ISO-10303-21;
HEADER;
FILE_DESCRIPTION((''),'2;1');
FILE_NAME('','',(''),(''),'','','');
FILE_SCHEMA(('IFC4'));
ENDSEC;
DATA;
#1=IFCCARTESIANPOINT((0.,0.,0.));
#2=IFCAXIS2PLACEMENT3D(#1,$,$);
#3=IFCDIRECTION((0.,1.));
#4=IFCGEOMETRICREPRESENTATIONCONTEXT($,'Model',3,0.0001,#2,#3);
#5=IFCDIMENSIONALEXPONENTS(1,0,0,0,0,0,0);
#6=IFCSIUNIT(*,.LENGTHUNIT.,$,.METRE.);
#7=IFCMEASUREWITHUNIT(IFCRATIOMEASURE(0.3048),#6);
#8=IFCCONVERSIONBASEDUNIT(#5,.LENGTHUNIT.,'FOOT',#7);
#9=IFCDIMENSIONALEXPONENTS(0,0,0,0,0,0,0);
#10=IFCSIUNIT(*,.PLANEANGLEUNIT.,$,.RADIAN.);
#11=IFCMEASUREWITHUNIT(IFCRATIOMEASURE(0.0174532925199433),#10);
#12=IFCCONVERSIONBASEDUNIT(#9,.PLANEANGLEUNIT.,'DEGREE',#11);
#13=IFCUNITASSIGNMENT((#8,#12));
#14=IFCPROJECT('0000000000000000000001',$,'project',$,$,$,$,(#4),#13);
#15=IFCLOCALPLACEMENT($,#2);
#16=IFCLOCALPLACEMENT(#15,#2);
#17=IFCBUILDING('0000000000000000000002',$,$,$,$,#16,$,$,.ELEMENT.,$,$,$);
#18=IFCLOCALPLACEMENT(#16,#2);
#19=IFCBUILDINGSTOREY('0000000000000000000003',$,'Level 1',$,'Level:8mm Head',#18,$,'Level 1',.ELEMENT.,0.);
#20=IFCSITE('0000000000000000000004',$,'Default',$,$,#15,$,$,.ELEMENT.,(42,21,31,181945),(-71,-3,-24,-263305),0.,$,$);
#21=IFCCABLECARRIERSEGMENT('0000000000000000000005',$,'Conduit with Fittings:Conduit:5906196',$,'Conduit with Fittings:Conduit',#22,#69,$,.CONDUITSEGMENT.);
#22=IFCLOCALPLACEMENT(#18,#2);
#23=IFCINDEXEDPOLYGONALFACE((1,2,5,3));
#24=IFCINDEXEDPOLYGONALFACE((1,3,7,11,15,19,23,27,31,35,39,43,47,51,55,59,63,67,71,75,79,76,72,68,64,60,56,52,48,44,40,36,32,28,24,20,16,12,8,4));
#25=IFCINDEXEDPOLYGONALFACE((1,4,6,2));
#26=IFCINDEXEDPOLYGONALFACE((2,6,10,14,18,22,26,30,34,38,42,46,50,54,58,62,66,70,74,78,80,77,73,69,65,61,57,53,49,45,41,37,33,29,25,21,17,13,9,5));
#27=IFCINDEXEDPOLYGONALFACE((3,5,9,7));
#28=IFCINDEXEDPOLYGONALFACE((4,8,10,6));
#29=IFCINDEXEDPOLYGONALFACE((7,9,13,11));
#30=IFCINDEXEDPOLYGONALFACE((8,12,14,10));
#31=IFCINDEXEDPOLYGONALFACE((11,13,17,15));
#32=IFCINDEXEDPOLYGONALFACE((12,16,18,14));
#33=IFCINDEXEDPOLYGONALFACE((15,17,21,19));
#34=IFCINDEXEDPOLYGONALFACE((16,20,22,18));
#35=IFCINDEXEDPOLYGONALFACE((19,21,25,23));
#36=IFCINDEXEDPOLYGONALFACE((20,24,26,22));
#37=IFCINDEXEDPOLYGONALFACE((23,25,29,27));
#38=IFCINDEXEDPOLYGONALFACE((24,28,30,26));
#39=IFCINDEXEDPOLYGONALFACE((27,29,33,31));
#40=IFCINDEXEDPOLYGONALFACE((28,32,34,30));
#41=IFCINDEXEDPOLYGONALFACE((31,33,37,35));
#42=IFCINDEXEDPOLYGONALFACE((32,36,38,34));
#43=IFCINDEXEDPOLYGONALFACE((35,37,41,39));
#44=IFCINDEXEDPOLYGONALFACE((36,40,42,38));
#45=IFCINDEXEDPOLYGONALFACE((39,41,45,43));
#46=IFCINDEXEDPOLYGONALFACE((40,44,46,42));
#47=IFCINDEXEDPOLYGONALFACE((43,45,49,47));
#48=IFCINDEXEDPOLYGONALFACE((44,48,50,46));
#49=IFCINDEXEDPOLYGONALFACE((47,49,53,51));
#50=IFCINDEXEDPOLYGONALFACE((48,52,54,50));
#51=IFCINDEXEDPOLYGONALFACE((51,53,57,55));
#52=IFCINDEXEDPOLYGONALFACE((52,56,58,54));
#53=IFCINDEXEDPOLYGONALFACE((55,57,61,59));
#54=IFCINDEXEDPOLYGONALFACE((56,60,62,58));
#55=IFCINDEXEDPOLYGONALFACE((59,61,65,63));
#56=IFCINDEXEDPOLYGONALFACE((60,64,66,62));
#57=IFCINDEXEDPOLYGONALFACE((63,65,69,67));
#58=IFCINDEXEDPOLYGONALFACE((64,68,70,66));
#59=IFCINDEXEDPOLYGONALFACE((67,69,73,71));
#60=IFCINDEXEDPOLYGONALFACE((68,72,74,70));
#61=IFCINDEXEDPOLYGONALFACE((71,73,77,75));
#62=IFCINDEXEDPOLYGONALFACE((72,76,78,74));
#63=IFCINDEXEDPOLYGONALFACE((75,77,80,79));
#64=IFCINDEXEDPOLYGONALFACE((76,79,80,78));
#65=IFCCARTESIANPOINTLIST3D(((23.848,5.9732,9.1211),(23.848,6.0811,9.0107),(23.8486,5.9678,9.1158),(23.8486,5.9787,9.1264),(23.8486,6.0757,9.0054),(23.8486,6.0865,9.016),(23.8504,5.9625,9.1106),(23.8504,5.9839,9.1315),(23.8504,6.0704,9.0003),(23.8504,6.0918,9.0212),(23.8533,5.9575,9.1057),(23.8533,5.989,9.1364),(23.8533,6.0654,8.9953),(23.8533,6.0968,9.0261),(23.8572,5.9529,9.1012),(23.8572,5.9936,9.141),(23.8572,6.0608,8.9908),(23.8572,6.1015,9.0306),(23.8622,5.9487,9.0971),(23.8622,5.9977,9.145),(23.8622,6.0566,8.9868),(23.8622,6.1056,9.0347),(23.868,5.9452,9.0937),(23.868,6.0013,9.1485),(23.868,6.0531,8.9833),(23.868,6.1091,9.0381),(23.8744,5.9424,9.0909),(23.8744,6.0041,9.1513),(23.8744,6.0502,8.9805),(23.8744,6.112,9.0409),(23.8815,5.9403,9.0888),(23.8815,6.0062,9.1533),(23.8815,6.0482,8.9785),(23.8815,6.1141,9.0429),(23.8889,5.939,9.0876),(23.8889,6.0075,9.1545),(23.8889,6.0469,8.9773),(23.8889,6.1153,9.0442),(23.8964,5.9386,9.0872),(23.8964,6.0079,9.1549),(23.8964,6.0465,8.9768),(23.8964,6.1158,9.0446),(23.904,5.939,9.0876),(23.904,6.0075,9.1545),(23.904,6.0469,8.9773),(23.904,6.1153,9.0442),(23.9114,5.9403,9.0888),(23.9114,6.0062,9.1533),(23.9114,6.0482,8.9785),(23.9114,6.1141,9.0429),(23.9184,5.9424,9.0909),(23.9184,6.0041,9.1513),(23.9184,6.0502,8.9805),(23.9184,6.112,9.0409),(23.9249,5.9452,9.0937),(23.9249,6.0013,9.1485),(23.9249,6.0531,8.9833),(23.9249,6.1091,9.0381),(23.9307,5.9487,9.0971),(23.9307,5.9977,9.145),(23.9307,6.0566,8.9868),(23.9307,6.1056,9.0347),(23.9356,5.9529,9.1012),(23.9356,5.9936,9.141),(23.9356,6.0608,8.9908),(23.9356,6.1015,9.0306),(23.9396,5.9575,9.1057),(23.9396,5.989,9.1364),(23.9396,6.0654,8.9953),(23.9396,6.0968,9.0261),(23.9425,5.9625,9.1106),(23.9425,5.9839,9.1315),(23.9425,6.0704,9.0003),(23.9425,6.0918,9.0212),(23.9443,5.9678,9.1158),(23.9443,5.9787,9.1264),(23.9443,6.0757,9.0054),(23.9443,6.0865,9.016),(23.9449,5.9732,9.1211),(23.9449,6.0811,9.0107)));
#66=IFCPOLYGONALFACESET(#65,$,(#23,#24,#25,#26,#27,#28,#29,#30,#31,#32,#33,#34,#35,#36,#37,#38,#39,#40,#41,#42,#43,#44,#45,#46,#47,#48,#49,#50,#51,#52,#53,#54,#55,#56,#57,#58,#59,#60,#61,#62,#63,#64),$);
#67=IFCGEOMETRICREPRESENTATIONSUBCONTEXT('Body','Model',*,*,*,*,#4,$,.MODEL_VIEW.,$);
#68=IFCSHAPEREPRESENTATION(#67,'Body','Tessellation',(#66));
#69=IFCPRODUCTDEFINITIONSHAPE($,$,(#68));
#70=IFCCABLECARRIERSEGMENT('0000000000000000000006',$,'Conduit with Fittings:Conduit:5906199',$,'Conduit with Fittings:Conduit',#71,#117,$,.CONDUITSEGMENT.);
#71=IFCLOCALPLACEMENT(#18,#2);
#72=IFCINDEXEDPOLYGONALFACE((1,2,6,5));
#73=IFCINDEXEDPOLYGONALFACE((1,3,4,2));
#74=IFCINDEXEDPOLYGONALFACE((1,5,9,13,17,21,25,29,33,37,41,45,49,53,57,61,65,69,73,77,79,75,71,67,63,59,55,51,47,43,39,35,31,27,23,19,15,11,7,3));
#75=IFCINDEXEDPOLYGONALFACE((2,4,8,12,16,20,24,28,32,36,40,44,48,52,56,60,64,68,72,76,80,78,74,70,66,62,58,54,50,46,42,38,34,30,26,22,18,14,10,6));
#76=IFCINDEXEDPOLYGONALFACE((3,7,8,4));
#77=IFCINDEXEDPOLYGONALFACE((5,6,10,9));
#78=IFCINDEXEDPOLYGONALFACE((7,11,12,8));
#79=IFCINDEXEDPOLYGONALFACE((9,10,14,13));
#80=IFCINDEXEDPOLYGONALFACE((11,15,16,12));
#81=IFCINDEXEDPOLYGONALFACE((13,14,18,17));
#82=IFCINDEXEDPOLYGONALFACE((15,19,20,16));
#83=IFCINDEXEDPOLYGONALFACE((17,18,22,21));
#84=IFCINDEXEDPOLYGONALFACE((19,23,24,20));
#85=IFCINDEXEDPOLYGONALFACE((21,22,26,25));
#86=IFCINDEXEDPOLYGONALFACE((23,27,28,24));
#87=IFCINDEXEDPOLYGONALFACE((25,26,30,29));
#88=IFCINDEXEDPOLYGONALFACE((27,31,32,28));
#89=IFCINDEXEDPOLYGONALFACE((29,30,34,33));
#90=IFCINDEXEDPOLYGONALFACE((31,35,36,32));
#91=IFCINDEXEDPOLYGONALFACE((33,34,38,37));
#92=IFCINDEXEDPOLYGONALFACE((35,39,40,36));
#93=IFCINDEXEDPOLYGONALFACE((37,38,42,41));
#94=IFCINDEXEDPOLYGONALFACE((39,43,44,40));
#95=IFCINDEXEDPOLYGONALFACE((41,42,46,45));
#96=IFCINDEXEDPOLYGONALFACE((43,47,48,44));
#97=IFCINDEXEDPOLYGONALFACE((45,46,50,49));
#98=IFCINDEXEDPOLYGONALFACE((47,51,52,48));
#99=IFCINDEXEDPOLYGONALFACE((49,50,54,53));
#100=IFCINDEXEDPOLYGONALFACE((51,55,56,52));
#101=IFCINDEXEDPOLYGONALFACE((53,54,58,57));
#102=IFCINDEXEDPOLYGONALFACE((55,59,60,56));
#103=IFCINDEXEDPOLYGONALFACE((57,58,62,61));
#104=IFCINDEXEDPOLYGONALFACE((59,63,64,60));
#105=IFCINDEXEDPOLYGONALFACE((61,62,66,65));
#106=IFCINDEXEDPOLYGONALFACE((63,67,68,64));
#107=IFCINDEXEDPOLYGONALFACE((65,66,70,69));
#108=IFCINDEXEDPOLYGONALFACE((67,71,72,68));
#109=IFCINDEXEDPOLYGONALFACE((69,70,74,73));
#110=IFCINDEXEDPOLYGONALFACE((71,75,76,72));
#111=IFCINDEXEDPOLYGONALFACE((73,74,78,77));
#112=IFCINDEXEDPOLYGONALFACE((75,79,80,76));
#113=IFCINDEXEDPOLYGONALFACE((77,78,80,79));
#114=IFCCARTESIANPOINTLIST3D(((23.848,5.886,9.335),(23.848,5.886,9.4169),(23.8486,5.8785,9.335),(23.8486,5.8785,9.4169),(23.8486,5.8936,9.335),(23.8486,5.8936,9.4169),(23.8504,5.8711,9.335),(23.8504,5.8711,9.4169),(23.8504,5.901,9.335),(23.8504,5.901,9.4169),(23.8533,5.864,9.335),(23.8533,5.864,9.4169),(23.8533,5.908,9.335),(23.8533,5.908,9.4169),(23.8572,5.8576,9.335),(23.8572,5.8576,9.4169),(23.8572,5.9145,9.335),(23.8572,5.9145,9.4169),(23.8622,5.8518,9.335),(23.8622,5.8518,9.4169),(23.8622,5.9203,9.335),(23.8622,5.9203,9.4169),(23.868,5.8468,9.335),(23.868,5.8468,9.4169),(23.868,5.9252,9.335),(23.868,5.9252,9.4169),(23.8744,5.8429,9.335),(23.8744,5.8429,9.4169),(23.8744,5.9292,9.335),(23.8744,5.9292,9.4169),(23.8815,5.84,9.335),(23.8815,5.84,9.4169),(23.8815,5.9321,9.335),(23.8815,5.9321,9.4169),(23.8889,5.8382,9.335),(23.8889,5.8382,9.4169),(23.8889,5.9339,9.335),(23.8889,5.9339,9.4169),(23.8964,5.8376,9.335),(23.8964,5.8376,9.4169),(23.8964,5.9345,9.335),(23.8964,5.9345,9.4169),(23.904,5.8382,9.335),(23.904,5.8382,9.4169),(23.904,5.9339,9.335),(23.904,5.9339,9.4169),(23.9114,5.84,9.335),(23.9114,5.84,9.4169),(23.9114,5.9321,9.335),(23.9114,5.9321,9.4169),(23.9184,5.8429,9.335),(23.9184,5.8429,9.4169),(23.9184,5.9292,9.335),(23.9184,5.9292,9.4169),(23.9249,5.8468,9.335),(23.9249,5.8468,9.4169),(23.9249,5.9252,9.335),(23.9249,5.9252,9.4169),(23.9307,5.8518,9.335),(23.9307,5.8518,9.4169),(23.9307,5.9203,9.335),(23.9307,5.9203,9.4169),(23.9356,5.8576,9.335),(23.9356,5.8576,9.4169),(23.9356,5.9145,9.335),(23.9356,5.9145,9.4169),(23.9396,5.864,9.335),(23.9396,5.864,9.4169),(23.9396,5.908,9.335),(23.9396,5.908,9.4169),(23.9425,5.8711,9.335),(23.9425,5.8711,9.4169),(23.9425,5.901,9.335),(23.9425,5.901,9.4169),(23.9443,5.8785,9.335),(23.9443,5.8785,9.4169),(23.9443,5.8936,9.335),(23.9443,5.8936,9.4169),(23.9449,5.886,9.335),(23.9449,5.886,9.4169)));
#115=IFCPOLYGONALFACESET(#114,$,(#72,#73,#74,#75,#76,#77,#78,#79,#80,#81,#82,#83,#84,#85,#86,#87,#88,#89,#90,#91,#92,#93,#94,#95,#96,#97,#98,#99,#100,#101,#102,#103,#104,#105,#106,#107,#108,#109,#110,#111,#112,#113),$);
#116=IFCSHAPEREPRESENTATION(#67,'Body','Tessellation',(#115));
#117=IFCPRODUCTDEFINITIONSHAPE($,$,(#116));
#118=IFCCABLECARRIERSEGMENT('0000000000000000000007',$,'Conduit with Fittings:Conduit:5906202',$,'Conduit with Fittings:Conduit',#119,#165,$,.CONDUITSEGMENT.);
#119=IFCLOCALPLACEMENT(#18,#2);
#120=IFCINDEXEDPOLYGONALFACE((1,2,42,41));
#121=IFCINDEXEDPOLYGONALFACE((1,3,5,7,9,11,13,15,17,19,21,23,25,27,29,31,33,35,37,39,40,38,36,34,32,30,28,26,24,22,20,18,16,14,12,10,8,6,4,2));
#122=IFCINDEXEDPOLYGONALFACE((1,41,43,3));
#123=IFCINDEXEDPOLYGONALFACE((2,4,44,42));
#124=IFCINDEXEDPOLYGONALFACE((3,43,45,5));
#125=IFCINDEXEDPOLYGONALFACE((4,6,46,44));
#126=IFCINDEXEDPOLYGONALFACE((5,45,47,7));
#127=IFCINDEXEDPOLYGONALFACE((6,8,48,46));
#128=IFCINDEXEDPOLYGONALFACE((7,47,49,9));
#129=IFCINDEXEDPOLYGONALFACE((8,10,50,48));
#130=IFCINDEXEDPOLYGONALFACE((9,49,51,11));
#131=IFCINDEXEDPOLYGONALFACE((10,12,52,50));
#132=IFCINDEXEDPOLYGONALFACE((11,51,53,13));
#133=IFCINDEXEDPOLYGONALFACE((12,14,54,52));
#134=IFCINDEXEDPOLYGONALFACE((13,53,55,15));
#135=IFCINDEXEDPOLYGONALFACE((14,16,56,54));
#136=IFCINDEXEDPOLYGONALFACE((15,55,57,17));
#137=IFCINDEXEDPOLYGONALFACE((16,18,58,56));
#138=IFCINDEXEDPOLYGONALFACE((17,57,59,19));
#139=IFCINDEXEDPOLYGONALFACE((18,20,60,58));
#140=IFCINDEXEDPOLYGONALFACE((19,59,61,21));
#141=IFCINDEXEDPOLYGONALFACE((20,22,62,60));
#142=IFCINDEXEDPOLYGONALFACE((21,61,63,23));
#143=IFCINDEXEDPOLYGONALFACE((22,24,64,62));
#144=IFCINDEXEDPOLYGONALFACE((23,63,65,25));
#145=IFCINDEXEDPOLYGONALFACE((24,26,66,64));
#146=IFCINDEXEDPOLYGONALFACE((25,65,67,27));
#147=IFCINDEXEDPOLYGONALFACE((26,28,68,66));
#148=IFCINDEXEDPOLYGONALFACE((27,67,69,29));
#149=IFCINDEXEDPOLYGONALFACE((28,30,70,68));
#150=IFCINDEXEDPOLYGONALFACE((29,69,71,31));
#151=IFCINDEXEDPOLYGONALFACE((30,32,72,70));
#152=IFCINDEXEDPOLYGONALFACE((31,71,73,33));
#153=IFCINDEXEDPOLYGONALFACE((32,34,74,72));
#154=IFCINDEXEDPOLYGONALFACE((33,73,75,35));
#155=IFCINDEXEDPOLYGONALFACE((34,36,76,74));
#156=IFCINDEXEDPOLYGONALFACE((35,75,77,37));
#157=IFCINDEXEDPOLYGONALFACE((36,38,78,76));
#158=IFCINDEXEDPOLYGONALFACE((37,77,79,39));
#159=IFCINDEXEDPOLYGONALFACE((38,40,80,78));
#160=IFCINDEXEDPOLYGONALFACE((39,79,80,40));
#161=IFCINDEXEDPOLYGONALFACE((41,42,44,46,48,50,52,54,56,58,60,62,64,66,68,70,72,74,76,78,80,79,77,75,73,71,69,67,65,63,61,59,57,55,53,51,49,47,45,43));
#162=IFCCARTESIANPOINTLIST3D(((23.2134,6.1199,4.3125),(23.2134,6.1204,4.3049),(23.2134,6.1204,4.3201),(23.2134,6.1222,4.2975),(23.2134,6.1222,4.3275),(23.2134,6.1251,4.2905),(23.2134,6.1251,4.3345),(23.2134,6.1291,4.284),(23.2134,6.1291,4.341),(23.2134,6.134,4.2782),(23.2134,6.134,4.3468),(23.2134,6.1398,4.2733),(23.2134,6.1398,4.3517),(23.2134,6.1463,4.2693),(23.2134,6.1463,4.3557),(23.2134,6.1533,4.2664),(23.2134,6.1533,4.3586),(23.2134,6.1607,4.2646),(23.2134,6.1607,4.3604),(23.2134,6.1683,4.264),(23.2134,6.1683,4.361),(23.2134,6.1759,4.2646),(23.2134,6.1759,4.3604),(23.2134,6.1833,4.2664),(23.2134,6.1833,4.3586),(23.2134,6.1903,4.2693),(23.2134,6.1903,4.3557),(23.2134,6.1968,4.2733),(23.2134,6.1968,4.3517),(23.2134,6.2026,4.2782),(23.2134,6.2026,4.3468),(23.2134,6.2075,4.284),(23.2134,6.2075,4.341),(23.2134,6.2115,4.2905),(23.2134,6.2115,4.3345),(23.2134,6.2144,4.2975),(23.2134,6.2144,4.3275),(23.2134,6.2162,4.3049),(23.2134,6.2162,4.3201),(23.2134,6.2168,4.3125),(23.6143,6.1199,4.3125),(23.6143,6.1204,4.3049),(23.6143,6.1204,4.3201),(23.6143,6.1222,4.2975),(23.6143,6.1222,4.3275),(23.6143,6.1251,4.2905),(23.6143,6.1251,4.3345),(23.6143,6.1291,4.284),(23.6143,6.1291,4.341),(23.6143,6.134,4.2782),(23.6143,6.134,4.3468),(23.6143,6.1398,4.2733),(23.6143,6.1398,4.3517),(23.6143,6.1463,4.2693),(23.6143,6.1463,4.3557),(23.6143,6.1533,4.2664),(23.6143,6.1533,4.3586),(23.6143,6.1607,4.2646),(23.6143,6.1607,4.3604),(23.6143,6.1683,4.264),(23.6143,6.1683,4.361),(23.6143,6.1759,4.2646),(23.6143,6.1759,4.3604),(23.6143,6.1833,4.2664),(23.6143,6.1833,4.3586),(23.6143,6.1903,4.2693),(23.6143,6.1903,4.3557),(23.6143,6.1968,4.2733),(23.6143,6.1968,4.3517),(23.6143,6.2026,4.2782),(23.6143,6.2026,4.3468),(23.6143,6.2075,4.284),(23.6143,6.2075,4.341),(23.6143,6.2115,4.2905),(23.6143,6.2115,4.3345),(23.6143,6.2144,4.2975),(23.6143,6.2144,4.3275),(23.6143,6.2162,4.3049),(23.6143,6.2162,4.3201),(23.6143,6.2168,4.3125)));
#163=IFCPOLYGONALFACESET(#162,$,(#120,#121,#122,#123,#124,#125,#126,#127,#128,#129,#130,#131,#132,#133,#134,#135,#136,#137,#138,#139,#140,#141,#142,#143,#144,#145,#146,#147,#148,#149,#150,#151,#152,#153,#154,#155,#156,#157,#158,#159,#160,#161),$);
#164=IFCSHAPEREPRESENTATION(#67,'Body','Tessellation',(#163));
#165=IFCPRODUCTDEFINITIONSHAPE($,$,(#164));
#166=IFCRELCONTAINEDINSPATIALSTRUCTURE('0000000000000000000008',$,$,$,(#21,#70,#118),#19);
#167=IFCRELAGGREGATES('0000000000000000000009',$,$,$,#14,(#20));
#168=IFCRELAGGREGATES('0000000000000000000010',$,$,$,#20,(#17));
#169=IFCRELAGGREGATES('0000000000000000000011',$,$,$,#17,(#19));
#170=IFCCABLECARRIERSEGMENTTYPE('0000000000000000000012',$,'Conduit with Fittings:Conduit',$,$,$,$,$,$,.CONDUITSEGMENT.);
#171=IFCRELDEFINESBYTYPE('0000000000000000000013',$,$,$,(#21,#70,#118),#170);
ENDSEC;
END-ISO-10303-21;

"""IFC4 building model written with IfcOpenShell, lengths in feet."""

from ifc_helpers import new_model, entity, si_unit, converted_unit, direction, frame, origin, place, context, subcontext, project, spatial, indexed_curve, outline, extrude, type_object, element, save


model = new_model("IFC4")

# Units and contexts
model_context = context("Model", 3, precision=0.0001, world=origin(), true_north=direction((0.0, 1.0)))
body_context = subcontext(model_context, "Body", "Model", "MODEL_VIEW")
ifc_project = project(units=[converted_unit("LENGTHUNIT", "FOOT", entity("IfcRatioMeasure", 0.3048), si_unit("LENGTHUNIT", "METRE"), dimensions=[1, 0, 0, 0, 0, 0, 0]), converted_unit("PLANEANGLEUNIT", "DEGREE", entity("IfcRatioMeasure", 0.0174532925199433), si_unit("PLANEANGLEUNIT", "RADIAN"), dimensions=[0, 0, 0, 0, 0, 0, 0])], contexts=[model_context])

# Site, building, storey
site_placement = place(None, origin())
site = spatial("IfcSite", under=ifc_project, at=site_placement, Name="Default", CompositionType="ELEMENT", RefLatitude=(42, 21, 31, 181945), RefLongitude=(-71, -3, -24, -263305), RefElevation=0.0)
building_placement = place(site_placement, origin())
building = spatial("IfcBuilding", under=site, at=building_placement, CompositionType="ELEMENT")
storey_placement = place(building_placement, origin())
storey = spatial("IfcBuildingStorey", under=building, at=storey_placement, Name="Level 1", ObjectType="Level:8mm Head", LongName="Level 1", CompositionType="ELEMENT", Elevation=0.0)

# Cable carrier segments
cable_carrier_segment_type_1 = type_object("IfcCableCarrierSegmentType", Name="Conduit with Fittings:Conduit", PredefinedType="CONDUITSEGMENT")
cable_carrier_segment_1_placement = place(storey_placement, origin())
element("IfcCableCarrierSegment", 1, at=cable_carrier_segment_1_placement, inside=storey, type_object=cable_carrier_segment_type_1, Name="Conduit with Fittings:Conduit:5906196", ObjectType="Conduit with Fittings:Conduit", PredefinedType="CONDUITSEGMENT", context=body_context, shape_type="SweptSolid", body=[
    extrude(outline(indexed_curve([(0.0485, 0.0), (0.0479, 0.0076), (0.0461, 0.015), (0.0432, 0.022), (0.0392, 0.0285), (0.0343, 0.0343), (0.0285, 0.0392), (0.022, 0.0432), (0.015, 0.0461), (0.0076, 0.0479), (0.0, 0.0485), (-0.0076, 0.0479), (-0.015, 0.0461), (-0.022, 0.0432), (-0.0285, 0.0392), (-0.0343, 0.0343), (-0.0392, 0.0285), (-0.0432, 0.022), (-0.0461, 0.015), (-0.0479, 0.0076), (-0.0485, 0.0), (-0.0479, -0.0076), (-0.0461, -0.015), (-0.0432, -0.022), (-0.0392, -0.0285), (-0.0343, -0.0343), (-0.0285, -0.0392), (-0.022, -0.0432), (-0.015, -0.0461), (-0.0076, -0.0479), (0.0, -0.0485), (0.0076, -0.0479), (0.015, -0.0461), (0.022, -0.0432), (0.0285, -0.0392), (0.0343, -0.0343), (0.0392, -0.0285), (0.0432, -0.022), (0.0461, -0.015), (0.0479, -0.0076), (0.0485, 0.0)], self_intersect=False)), frame((23.8964, 6.0811, 9.0107), z_axis=(0.0, -0.699077, 0.715046), x_axis=(-1.0, 0.0, 0.0)), (0.0, 0.0, 1.0), 0.1543),
])
cable_carrier_segment_2_placement = place(storey_placement, origin())
element("IfcCableCarrierSegment", 2, at=cable_carrier_segment_2_placement, inside=storey, type_object=cable_carrier_segment_type_1, Name="Conduit with Fittings:Conduit:5906199", ObjectType="Conduit with Fittings:Conduit", PredefinedType="CONDUITSEGMENT", context=body_context, shape_type="SweptSolid", body=[
    extrude(outline(indexed_curve([(0.0485, 0.0), (0.0479, 0.0076), (0.0461, 0.015), (0.0432, 0.022), (0.0392, 0.0285), (0.0343, 0.0343), (0.0285, 0.0392), (0.022, 0.0432), (0.015, 0.0461), (0.0076, 0.0479), (0.0, 0.0485), (-0.0076, 0.0479), (-0.015, 0.0461), (-0.022, 0.0432), (-0.0285, 0.0392), (-0.0343, 0.0343), (-0.0392, 0.0285), (-0.0432, 0.022), (-0.0461, 0.015), (-0.0479, 0.0076), (-0.0485, 0.0), (-0.0479, -0.0076), (-0.0461, -0.015), (-0.0432, -0.022), (-0.0392, -0.0285), (-0.0343, -0.0343), (-0.0285, -0.0392), (-0.022, -0.0432), (-0.015, -0.0461), (-0.0076, -0.0479), (0.0, -0.0485), (0.0076, -0.0479), (0.015, -0.0461), (0.022, -0.0432), (0.0285, -0.0392), (0.0343, -0.0343), (0.0392, -0.0285), (0.0432, -0.022), (0.0461, -0.015), (0.0479, -0.0076), (0.0485, 0.0)], self_intersect=False)), frame((23.8964, 5.886, 9.335), z_axis=(0.0, 0.0, 1.0), x_axis=(-1.0, 0.0, 0.0)), (0.0, 0.0, 1.0), 0.082),
])
cable_carrier_segment_3_placement = place(storey_placement, origin())
element("IfcCableCarrierSegment", 3, at=cable_carrier_segment_3_placement, inside=storey, type_object=cable_carrier_segment_type_1, Name="Conduit with Fittings:Conduit:5906202", ObjectType="Conduit with Fittings:Conduit", PredefinedType="CONDUITSEGMENT", context=body_context, shape_type="SweptSolid", body=[
    extrude(outline(indexed_curve([(0.0485, 0.0), (0.0479, 0.0076), (0.0461, 0.015), (0.0432, 0.022), (0.0392, 0.0285), (0.0343, 0.0343), (0.0285, 0.0392), (0.022, 0.0432), (0.015, 0.0461), (0.0076, 0.0479), (0.0, 0.0485), (-0.0076, 0.0479), (-0.015, 0.0461), (-0.022, 0.0432), (-0.0285, 0.0392), (-0.0343, 0.0343), (-0.0392, 0.0285), (-0.0432, 0.022), (-0.0461, 0.015), (-0.0479, 0.0076), (-0.0485, 0.0), (-0.0479, -0.0076), (-0.0461, -0.015), (-0.0432, -0.022), (-0.0392, -0.0285), (-0.0343, -0.0343), (-0.0285, -0.0392), (-0.022, -0.0432), (-0.015, -0.0461), (-0.0076, -0.0479), (0.0, -0.0485), (0.0076, -0.0479), (0.015, -0.0461), (0.022, -0.0432), (0.0285, -0.0392), (0.0343, -0.0343), (0.0392, -0.0285), (0.0432, -0.022), (0.0461, -0.015), (0.0479, -0.0076), (0.0485, 0.0)], self_intersect=False)), frame((23.2134, 6.1683, 4.3125), z_axis=(1.0, 0.0, 0.0), x_axis=(0.0, 1.0, 0.0)), (0.0, 0.0, 1.0), 0.4009),
])

save(model, "model.ifc")
